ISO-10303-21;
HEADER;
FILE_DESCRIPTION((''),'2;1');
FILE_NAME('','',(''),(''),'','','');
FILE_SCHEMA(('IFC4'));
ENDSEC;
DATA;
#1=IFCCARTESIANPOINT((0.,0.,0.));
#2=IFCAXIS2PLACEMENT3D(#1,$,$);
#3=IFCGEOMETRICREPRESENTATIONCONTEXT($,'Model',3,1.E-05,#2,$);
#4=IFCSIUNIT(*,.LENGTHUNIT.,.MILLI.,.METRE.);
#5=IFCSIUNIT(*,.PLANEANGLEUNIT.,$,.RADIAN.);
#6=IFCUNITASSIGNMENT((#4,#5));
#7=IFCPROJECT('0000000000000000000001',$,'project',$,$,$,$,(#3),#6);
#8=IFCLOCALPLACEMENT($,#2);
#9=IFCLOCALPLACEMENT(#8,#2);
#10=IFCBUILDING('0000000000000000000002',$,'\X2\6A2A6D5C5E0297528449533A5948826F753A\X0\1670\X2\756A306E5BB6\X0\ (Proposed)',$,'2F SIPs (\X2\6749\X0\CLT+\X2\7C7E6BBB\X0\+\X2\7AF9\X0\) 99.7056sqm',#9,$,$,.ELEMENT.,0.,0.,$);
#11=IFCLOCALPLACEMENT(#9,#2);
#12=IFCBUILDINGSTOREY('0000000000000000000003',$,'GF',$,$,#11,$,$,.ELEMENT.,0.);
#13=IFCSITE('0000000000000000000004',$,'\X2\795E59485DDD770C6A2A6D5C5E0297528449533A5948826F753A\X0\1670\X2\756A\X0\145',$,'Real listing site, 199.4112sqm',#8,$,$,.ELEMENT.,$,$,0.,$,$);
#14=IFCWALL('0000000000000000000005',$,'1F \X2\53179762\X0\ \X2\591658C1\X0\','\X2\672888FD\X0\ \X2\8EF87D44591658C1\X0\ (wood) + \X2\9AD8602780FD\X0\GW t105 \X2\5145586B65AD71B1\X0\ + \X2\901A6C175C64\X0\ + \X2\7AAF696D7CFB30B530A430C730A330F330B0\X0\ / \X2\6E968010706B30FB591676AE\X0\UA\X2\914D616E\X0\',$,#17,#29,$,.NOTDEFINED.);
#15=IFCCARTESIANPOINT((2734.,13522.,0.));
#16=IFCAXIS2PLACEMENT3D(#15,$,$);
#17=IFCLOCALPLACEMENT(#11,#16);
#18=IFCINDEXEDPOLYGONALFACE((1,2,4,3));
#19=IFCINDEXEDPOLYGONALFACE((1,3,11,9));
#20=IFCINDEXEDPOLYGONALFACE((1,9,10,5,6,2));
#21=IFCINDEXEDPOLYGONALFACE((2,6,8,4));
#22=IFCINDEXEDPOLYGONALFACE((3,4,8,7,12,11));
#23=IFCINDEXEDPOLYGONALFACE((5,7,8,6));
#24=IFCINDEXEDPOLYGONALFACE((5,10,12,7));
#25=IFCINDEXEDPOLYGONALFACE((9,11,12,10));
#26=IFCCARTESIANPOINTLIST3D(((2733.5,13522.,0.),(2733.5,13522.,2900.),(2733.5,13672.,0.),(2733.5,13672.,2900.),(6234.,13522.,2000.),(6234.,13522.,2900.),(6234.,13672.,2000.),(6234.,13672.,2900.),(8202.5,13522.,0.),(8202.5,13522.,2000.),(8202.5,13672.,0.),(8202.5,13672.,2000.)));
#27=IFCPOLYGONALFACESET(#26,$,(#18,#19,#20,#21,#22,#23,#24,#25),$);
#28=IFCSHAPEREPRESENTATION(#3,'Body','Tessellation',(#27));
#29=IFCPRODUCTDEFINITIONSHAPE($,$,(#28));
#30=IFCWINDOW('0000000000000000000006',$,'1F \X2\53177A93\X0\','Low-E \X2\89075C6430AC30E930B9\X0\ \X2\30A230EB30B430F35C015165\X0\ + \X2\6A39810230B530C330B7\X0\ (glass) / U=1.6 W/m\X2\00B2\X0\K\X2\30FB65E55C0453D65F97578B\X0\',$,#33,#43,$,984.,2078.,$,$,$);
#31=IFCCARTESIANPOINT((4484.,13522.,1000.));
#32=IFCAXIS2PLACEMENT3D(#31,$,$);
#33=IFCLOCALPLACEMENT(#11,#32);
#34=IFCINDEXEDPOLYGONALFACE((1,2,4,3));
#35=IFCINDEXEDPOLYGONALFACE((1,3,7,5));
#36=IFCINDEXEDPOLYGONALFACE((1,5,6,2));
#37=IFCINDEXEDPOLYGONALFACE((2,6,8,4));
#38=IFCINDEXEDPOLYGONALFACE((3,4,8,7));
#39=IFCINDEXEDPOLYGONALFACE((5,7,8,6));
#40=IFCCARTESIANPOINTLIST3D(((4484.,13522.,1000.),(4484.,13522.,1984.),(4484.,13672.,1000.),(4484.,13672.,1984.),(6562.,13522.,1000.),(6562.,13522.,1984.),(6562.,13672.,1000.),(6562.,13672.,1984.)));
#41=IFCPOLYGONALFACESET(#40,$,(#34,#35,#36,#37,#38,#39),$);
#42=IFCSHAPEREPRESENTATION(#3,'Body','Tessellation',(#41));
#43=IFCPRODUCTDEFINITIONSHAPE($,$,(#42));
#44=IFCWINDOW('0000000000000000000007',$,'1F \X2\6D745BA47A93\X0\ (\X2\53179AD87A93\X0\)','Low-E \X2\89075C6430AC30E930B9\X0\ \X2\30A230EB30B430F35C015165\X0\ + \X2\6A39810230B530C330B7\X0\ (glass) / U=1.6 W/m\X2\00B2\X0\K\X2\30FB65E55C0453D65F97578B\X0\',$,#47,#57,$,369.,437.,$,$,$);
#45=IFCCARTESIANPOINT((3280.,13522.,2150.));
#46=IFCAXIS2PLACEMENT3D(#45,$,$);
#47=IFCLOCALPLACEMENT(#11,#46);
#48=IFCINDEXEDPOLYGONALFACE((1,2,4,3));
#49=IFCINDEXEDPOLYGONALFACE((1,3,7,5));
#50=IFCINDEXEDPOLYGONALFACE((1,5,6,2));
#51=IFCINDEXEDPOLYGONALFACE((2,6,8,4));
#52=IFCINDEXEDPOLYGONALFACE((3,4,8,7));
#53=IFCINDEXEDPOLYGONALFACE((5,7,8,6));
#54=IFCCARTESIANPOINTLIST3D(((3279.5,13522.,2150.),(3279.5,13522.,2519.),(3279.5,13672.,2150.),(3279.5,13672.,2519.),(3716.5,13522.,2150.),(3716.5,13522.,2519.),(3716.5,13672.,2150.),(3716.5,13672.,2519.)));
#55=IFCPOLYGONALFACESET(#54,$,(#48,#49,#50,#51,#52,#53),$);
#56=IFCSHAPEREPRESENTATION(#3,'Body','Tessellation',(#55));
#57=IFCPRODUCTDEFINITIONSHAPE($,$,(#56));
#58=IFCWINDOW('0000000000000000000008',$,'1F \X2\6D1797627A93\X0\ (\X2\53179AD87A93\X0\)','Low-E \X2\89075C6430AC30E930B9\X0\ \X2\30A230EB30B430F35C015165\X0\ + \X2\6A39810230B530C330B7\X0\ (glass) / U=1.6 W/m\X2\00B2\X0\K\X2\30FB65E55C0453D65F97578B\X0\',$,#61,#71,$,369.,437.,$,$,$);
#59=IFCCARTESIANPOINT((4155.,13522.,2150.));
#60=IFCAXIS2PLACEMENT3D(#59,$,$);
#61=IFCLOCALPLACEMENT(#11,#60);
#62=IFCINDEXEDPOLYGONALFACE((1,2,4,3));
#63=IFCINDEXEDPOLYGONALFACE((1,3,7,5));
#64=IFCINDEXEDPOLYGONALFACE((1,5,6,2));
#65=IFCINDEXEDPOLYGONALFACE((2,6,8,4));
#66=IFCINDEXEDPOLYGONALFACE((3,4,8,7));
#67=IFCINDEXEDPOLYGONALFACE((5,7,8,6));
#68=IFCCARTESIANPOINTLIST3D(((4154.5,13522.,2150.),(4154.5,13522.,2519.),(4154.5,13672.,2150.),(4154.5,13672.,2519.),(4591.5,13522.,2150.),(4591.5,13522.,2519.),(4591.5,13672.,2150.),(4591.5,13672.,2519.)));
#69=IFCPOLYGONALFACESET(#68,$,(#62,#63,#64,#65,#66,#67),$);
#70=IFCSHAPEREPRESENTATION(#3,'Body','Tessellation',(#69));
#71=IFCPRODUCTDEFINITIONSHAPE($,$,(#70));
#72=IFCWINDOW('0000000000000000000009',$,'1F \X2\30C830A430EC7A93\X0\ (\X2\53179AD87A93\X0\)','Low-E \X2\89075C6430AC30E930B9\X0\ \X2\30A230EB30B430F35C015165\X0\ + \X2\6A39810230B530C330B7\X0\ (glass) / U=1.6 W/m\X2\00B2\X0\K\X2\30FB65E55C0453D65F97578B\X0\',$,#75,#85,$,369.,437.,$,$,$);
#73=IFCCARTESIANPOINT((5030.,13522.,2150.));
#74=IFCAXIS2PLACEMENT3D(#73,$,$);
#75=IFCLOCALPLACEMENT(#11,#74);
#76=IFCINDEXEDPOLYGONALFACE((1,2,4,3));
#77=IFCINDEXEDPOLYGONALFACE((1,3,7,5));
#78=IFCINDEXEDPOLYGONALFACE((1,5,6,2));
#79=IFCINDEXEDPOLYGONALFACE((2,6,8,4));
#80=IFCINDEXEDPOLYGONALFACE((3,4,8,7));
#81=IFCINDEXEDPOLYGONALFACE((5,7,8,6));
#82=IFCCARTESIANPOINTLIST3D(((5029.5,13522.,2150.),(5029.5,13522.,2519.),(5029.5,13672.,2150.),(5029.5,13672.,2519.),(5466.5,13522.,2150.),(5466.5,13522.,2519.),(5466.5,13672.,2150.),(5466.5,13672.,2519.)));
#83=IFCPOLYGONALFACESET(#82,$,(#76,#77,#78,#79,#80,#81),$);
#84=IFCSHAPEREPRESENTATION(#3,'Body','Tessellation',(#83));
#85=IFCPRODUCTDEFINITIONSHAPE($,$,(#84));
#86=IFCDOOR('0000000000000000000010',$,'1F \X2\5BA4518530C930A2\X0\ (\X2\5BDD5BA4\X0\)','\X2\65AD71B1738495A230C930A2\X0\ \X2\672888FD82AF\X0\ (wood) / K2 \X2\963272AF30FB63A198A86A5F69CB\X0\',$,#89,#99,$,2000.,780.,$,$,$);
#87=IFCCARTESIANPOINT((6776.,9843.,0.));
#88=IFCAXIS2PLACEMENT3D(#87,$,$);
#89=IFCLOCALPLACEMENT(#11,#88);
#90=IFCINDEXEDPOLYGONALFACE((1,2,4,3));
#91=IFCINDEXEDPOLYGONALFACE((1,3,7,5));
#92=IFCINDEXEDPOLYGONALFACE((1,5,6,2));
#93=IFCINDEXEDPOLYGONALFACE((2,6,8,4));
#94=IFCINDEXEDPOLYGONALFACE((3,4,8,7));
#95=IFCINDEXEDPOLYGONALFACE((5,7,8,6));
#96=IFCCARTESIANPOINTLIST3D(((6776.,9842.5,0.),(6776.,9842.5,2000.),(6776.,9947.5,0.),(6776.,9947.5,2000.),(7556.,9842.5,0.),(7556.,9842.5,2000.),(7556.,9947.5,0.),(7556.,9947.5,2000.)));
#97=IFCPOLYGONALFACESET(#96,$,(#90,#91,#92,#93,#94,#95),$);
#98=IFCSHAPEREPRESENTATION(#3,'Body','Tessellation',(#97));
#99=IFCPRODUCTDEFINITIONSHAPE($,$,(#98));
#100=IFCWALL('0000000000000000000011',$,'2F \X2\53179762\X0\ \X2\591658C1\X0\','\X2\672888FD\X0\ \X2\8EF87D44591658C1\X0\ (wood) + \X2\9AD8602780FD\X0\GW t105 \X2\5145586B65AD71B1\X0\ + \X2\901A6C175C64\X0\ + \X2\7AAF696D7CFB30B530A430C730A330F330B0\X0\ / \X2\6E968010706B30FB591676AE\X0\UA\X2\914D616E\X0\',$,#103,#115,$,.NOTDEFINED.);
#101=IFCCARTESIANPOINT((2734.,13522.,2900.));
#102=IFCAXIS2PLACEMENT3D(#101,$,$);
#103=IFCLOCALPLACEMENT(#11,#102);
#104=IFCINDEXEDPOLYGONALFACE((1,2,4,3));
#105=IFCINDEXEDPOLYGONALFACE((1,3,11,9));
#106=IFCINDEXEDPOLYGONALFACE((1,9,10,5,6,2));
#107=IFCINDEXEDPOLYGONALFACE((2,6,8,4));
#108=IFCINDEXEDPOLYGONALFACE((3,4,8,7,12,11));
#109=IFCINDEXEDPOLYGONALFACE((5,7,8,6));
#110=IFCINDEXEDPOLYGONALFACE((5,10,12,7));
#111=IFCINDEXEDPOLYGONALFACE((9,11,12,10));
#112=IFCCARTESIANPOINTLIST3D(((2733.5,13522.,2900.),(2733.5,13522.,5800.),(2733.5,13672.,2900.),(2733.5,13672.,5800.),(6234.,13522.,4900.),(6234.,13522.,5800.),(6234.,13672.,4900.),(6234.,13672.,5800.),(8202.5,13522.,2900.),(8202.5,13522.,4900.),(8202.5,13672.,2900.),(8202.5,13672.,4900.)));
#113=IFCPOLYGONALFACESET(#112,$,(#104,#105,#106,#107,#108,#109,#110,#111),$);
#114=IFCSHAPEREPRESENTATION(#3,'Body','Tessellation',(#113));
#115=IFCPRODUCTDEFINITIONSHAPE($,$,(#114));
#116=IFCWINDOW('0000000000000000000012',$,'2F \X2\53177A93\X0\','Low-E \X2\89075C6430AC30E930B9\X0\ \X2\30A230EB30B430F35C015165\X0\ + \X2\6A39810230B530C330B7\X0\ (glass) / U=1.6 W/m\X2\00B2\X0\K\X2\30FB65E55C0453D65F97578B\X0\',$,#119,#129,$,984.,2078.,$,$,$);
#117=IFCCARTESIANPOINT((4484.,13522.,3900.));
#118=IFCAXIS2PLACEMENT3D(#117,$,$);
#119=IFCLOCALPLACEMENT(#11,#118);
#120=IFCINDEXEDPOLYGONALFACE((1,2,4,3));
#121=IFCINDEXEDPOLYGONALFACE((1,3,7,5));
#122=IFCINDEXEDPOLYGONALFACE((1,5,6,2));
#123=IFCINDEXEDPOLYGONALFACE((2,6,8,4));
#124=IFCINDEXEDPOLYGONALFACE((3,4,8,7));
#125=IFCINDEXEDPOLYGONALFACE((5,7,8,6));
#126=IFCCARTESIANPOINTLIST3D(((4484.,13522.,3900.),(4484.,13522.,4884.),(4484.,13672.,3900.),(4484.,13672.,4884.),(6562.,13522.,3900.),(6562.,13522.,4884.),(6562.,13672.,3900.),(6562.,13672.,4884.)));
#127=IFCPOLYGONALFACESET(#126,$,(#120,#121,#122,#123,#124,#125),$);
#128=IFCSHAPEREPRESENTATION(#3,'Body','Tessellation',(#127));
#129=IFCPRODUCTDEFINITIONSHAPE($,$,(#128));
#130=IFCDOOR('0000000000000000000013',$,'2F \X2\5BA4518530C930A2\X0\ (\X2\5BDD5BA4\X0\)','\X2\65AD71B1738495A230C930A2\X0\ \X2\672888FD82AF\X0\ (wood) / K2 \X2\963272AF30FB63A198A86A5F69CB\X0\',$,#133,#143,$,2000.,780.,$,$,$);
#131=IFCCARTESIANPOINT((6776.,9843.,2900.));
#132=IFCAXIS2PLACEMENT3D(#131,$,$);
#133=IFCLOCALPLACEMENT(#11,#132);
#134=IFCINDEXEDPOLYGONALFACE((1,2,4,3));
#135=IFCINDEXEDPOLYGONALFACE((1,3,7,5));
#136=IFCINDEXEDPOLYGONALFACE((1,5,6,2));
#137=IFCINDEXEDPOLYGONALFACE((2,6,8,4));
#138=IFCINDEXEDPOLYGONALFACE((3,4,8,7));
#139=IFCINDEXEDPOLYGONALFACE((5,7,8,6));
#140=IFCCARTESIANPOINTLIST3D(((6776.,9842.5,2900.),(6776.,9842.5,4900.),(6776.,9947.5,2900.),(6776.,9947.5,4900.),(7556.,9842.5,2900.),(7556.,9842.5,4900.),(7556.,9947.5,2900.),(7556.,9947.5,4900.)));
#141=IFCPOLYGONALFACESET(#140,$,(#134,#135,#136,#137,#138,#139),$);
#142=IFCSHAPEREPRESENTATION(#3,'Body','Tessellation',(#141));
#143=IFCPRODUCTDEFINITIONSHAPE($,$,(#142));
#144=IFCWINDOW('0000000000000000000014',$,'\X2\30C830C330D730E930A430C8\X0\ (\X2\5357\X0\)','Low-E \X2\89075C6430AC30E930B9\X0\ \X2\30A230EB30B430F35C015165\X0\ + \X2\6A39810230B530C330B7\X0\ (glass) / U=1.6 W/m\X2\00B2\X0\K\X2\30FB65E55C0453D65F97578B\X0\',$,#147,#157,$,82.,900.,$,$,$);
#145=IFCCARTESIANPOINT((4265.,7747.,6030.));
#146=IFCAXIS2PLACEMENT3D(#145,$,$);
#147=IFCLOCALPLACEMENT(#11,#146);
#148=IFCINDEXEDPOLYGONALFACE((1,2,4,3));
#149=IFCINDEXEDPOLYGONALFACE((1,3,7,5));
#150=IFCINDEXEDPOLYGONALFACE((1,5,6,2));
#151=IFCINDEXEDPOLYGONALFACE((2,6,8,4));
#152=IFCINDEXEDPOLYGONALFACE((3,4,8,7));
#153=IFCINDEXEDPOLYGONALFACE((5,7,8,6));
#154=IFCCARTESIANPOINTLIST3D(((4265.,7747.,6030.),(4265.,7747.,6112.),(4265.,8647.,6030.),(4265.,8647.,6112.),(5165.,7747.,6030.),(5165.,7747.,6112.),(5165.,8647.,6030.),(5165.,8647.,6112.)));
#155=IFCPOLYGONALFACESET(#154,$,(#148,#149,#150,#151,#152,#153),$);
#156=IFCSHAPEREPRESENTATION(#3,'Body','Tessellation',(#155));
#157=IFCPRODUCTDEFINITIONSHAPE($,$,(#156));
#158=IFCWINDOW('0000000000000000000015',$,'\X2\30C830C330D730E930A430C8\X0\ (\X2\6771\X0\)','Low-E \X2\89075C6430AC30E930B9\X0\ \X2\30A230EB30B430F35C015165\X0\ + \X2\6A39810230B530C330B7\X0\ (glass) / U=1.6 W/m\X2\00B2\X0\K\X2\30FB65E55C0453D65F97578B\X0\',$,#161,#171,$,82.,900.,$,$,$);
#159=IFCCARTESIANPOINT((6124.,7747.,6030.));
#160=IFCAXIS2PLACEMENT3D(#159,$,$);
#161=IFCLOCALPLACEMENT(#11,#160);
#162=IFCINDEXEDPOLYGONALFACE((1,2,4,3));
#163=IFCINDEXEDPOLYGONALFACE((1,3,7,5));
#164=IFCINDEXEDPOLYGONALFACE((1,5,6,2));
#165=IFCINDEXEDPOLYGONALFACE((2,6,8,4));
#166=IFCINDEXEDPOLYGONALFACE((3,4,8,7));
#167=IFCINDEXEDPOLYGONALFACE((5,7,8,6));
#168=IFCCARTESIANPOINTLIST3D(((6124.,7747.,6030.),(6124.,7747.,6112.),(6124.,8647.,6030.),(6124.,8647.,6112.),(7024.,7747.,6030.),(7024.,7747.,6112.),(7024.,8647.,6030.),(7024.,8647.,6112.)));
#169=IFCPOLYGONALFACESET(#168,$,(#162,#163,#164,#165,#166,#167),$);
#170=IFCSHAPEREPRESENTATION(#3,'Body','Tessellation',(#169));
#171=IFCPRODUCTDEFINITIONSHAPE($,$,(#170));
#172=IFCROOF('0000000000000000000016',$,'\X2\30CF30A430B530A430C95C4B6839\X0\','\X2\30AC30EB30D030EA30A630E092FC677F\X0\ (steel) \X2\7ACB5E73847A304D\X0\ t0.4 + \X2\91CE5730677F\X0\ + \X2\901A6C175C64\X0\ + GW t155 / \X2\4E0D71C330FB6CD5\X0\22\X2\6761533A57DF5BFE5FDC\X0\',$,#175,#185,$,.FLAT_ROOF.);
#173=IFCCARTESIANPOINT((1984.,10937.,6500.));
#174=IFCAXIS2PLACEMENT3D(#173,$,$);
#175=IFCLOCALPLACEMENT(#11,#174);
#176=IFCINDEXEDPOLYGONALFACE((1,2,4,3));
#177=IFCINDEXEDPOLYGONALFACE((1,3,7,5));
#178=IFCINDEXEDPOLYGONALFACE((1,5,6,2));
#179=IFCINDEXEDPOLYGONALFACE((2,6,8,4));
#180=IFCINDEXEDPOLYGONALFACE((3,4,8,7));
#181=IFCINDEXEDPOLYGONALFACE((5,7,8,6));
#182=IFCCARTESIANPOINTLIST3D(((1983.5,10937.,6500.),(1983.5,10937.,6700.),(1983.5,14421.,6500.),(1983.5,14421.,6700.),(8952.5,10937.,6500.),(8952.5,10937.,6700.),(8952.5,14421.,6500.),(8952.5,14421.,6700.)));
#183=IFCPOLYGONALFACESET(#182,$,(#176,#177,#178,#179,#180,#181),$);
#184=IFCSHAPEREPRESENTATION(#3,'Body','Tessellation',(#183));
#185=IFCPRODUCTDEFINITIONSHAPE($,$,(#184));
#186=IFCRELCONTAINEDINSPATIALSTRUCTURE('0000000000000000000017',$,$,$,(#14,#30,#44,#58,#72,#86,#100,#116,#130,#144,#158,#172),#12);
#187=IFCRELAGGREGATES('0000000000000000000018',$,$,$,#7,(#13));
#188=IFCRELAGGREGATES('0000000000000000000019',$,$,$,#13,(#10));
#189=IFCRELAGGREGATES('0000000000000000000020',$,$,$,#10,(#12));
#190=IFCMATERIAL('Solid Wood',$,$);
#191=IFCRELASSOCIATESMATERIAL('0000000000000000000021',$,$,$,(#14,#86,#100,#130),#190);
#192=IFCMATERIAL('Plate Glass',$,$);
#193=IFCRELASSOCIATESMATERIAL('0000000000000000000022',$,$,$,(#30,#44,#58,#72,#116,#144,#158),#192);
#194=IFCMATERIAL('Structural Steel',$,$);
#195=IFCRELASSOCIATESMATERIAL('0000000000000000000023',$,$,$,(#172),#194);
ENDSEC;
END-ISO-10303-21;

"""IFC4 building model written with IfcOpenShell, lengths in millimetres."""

from ifc_helpers import new_model, si_unit, frame, frame_2d, origin, place, context, project, spatial, rectangle, extrude, material, element, fill, save


model = new_model("IFC4")

# Units and contexts
model_context = context("Model", 3, precision=1e-05, world=origin())
ifc_project = project(units=[si_unit("LENGTHUNIT", "METRE", prefix="MILLI"), si_unit("PLANEANGLEUNIT", "RADIAN")], contexts=[model_context])

# Site, building, storey
site_placement = place(None, origin())
site = spatial("IfcSite", under=ifc_project, at=site_placement, Name="神奈川県横浜市青葉区奈良町1670番145", ObjectType="Real listing site, 199.4112sqm", CompositionType="ELEMENT", RefElevation=0.0)
building_placement = place(site_placement, origin())
building = spatial("IfcBuilding", under=site, at=building_placement, Name="横浜市青葉区奈良町1670番の家 (Proposed)", ObjectType="2F SIPs (杉CLT+籾殻+竹) 99.7056sqm", CompositionType="ELEMENT", ElevationOfRefHeight=0.0, ElevationOfTerrain=0.0)
storey_placement = place(building_placement, origin())
storey = spatial("IfcBuildingStorey", under=building, at=storey_placement, Name="GF", CompositionType="ELEMENT", Elevation=0.0)

# Wall, openings, windows
ifc_material_1 = material(Name="Solid Wood")
wall_1_placement = place(storey_placement, frame((2734.0, 13522.0, 0.0)))
wall_1 = element("IfcWall", 1, at=wall_1_placement, inside=storey, material=ifc_material_1, Name="1F 北面 外壁", Description="木製 軸組外壁 (wood) + 高性能GW t105 充填断熱 + 通気層 + 窯業系サイディング / 準耐火・外皮UA配慮", PredefinedType="NOTDEFINED", context=model_context, shape_type="SweptSolid", body=[
    extrude(rectangle(XDim=5469.0, YDim=150.0, at=frame_2d((2734.0, 75.0))), frame((2734.0, 13522.0, 0.0)), (0.0, 0.0, 1.0), 2900.0),
])
opening_1_placement = place(storey_placement, frame((4484.0, 13522.0, 1000.0)))
opening_1 = element("IfcOpeningElement", 2, at=opening_1_placement, cuts=wall_1, PredefinedType="NOTDEFINED", context=model_context, shape_type="SweptSolid", body=[
    extrude(rectangle(XDim=2078.0, YDim=150.0, at=frame_2d((1039.0, 75.0))), frame((4484.0, 13522.0, 1000.0)), (0.0, 0.0, 1.0), 984.0),
])
opening_2_placement = place(storey_placement, frame((3280.0, 13522.0, 2150.0)))
opening_2 = element("IfcOpeningElement", 3, at=opening_2_placement, cuts=wall_1, PredefinedType="NOTDEFINED", context=model_context, shape_type="SweptSolid", body=[
    extrude(rectangle(XDim=437.0, YDim=150.0, at=frame_2d((218.0, 75.0))), frame((3280.0, 13522.0, 2150.0)), (0.0, 0.0, 1.0), 369.0),
])
opening_3_placement = place(storey_placement, frame((4155.0, 13522.0, 2150.0)))
opening_3 = element("IfcOpeningElement", 4, at=opening_3_placement, cuts=wall_1, PredefinedType="NOTDEFINED", context=model_context, shape_type="SweptSolid", body=[
    extrude(rectangle(XDim=437.0, YDim=150.0, at=frame_2d((218.0, 75.0))), frame((4155.0, 13522.0, 2150.0)), (0.0, 0.0, 1.0), 369.0),
])
opening_4_placement = place(storey_placement, frame((5030.0, 13522.0, 2150.0)))
opening_4 = element("IfcOpeningElement", 5, at=opening_4_placement, cuts=wall_1, PredefinedType="NOTDEFINED", context=model_context, shape_type="SweptSolid", body=[
    extrude(rectangle(XDim=437.0, YDim=150.0, at=frame_2d((218.0, 75.0))), frame((5030.0, 13522.0, 2150.0)), (0.0, 0.0, 1.0), 369.0),
])
ifc_material_2 = material(Name="Plate Glass")
window_1_placement = place(storey_placement, frame((4484.0, 13522.0, 1000.0)))
window_1 = element("IfcWindow", 6, at=window_1_placement, inside=storey, material=ifc_material_2, Name="1F 北窓", Description="Low-E 複層ガラス アルゴン封入 + 樹脂サッシ (glass) / U=1.6 W/m²K・日射取得型", OverallHeight=984.0, OverallWidth=2078.0, context=model_context, shape_type="SweptSolid", body=[
    extrude(rectangle(XDim=2078.0, YDim=150.0, at=frame_2d((1039.0, 75.0))), frame((4484.0, 13522.0, 1000.0)), (0.0, 0.0, 1.0), 984.0),
])
fill(opening_1, window_1)
window_2_placement = place(storey_placement, frame((3280.0, 13522.0, 2150.0)))
window_2 = element("IfcWindow", 7, at=window_2_placement, inside=storey, material=ifc_material_2, Name="1F 浴室窓 (北高窓)", Description="Low-E 複層ガラス アルゴン封入 + 樹脂サッシ (glass) / U=1.6 W/m²K・日射取得型", OverallHeight=369.0, OverallWidth=437.0, context=model_context, shape_type="SweptSolid", body=[
    extrude(rectangle(XDim=437.0, YDim=150.0, at=frame_2d((218.0, 75.0))), frame((3280.0, 13522.0, 2150.0)), (0.0, 0.0, 1.0), 369.0),
])
fill(opening_2, window_2)
window_3_placement = place(storey_placement, frame((4155.0, 13522.0, 2150.0)))
window_3 = element("IfcWindow", 8, at=window_3_placement, inside=storey, material=ifc_material_2, Name="1F 洗面窓 (北高窓)", Description="Low-E 複層ガラス アルゴン封入 + 樹脂サッシ (glass) / U=1.6 W/m²K・日射取得型", OverallHeight=369.0, OverallWidth=437.0, context=model_context, shape_type="SweptSolid", body=[
    extrude(rectangle(XDim=437.0, YDim=150.0, at=frame_2d((218.0, 75.0))), frame((4155.0, 13522.0, 2150.0)), (0.0, 0.0, 1.0), 369.0),
])
fill(opening_3, window_3)
window_4_placement = place(storey_placement, frame((5030.0, 13522.0, 2150.0)))
window_4 = element("IfcWindow", 9, at=window_4_placement, inside=storey, material=ifc_material_2, Name="1F トイレ窓 (北高窓)", Description="Low-E 複層ガラス アルゴン封入 + 樹脂サッシ (glass) / U=1.6 W/m²K・日射取得型", OverallHeight=369.0, OverallWidth=437.0, context=model_context, shape_type="SweptSolid", body=[
    extrude(rectangle(XDim=437.0, YDim=150.0, at=frame_2d((218.0, 75.0))), frame((5030.0, 13522.0, 2150.0)), (0.0, 0.0, 1.0), 369.0),
])
fill(opening_4, window_4)

# Door
door_1_placement = place(storey_placement, frame((6776.0, 9843.0, 0.0)))
element("IfcDoor", 10, at=door_1_placement, inside=storey, material=ifc_material_1, Name="1F 室内ドア (寝室)", Description="断熱玄関ドア 木製芯 (wood) / K2 防犯・採風機構", OverallHeight=2000.0, OverallWidth=780.0, context=model_context, shape_type="SweptSolid", body=[
    extrude(rectangle(XDim=780.0, YDim=105.0, at=frame_2d((390.0, 52.0))), frame((6776.0, 9843.0, 0.0)), (0.0, 0.0, 1.0), 2000.0),
])

# Wall, opening, window
wall_2_placement = place(storey_placement, frame((2734.0, 13522.0, 2900.0)))
wall_2 = element("IfcWall", 11, at=wall_2_placement, inside=storey, material=ifc_material_1, Name="2F 北面 外壁", Description="木製 軸組外壁 (wood) + 高性能GW t105 充填断熱 + 通気層 + 窯業系サイディング / 準耐火・外皮UA配慮", PredefinedType="NOTDEFINED", context=model_context, shape_type="SweptSolid", body=[
    extrude(rectangle(XDim=5469.0, YDim=150.0, at=frame_2d((2734.0, 75.0))), frame((2734.0, 13522.0, 2900.0)), (0.0, 0.0, 1.0), 2900.0),
])
opening_5_placement = place(storey_placement, frame((4484.0, 13522.0, 3900.0)))
opening_5 = element("IfcOpeningElement", 12, at=opening_5_placement, cuts=wall_2, PredefinedType="NOTDEFINED", context=model_context, shape_type="SweptSolid", body=[
    extrude(rectangle(XDim=2078.0, YDim=150.0, at=frame_2d((1039.0, 75.0))), frame((4484.0, 13522.0, 3900.0)), (0.0, 0.0, 1.0), 984.0),
])
window_5_placement = place(storey_placement, frame((4484.0, 13522.0, 3900.0)))
window_5 = element("IfcWindow", 13, at=window_5_placement, inside=storey, material=ifc_material_2, Name="2F 北窓", Description="Low-E 複層ガラス アルゴン封入 + 樹脂サッシ (glass) / U=1.6 W/m²K・日射取得型", OverallHeight=984.0, OverallWidth=2078.0, context=model_context, shape_type="SweptSolid", body=[
    extrude(rectangle(XDim=2078.0, YDim=150.0, at=frame_2d((1039.0, 75.0))), frame((4484.0, 13522.0, 3900.0)), (0.0, 0.0, 1.0), 984.0),
])
fill(opening_5, window_5)

# Door
door_2_placement = place(storey_placement, frame((6776.0, 9843.0, 2900.0)))
element("IfcDoor", 14, at=door_2_placement, inside=storey, material=ifc_material_1, Name="2F 室内ドア (寝室)", Description="断熱玄関ドア 木製芯 (wood) / K2 防犯・採風機構", OverallHeight=2000.0, OverallWidth=780.0, context=model_context, shape_type="SweptSolid", body=[
    extrude(rectangle(XDim=780.0, YDim=105.0, at=frame_2d((390.0, 52.0))), frame((6776.0, 9843.0, 2900.0)), (0.0, 0.0, 1.0), 2000.0),
])

# Windows
window_6_placement = place(storey_placement, frame((4265.0, 7747.0, 6030.0)))
element("IfcWindow", 15, at=window_6_placement, inside=storey, material=ifc_material_2, Name="トップライト (南)", Description="Low-E 複層ガラス アルゴン封入 + 樹脂サッシ (glass) / U=1.6 W/m²K・日射取得型", OverallHeight=82.0, OverallWidth=900.0, context=model_context, shape_type="SweptSolid", body=[
    extrude(rectangle(XDim=900.0, YDim=900.0, at=frame_2d((450.0, 450.0))), frame((4265.0, 7747.0, 6030.0)), (0.0, 0.0, 1.0), 82.0),
])
window_7_placement = place(storey_placement, frame((6124.0, 7747.0, 6030.0)))
element("IfcWindow", 16, at=window_7_placement, inside=storey, material=ifc_material_2, Name="トップライト (東)", Description="Low-E 複層ガラス アルゴン封入 + 樹脂サッシ (glass) / U=1.6 W/m²K・日射取得型", OverallHeight=82.0, OverallWidth=900.0, context=model_context, shape_type="SweptSolid", body=[
    extrude(rectangle(XDim=900.0, YDim=900.0, at=frame_2d((450.0, 450.0))), frame((6124.0, 7747.0, 6030.0)), (0.0, 0.0, 1.0), 82.0),
])

# Roof
ifc_material_3 = material(Name="Structural Steel")
roof_placement = place(storey_placement, frame((1984.0, 10937.0, 6500.0)))
element("IfcRoof", 17, at=roof_placement, inside=storey, material=ifc_material_3, Name="ハイサイド屋根", Description="ガルバリウム鋼板 (steel) 立平葺き t0.4 + 野地板 + 通気層 + GW t155 / 不燃・法22条区域対応", PredefinedType="FLAT_ROOF", context=model_context, shape_type="SweptSolid", body=[
    extrude(rectangle(XDim=6969.0, YDim=3484.0, at=frame_2d((3484.0, 1742.0))), frame((1984.0, 10937.0, 6500.0)), (0.0, 0.0, 1.0), 200.0),
])

save(model, "model.ifc")
